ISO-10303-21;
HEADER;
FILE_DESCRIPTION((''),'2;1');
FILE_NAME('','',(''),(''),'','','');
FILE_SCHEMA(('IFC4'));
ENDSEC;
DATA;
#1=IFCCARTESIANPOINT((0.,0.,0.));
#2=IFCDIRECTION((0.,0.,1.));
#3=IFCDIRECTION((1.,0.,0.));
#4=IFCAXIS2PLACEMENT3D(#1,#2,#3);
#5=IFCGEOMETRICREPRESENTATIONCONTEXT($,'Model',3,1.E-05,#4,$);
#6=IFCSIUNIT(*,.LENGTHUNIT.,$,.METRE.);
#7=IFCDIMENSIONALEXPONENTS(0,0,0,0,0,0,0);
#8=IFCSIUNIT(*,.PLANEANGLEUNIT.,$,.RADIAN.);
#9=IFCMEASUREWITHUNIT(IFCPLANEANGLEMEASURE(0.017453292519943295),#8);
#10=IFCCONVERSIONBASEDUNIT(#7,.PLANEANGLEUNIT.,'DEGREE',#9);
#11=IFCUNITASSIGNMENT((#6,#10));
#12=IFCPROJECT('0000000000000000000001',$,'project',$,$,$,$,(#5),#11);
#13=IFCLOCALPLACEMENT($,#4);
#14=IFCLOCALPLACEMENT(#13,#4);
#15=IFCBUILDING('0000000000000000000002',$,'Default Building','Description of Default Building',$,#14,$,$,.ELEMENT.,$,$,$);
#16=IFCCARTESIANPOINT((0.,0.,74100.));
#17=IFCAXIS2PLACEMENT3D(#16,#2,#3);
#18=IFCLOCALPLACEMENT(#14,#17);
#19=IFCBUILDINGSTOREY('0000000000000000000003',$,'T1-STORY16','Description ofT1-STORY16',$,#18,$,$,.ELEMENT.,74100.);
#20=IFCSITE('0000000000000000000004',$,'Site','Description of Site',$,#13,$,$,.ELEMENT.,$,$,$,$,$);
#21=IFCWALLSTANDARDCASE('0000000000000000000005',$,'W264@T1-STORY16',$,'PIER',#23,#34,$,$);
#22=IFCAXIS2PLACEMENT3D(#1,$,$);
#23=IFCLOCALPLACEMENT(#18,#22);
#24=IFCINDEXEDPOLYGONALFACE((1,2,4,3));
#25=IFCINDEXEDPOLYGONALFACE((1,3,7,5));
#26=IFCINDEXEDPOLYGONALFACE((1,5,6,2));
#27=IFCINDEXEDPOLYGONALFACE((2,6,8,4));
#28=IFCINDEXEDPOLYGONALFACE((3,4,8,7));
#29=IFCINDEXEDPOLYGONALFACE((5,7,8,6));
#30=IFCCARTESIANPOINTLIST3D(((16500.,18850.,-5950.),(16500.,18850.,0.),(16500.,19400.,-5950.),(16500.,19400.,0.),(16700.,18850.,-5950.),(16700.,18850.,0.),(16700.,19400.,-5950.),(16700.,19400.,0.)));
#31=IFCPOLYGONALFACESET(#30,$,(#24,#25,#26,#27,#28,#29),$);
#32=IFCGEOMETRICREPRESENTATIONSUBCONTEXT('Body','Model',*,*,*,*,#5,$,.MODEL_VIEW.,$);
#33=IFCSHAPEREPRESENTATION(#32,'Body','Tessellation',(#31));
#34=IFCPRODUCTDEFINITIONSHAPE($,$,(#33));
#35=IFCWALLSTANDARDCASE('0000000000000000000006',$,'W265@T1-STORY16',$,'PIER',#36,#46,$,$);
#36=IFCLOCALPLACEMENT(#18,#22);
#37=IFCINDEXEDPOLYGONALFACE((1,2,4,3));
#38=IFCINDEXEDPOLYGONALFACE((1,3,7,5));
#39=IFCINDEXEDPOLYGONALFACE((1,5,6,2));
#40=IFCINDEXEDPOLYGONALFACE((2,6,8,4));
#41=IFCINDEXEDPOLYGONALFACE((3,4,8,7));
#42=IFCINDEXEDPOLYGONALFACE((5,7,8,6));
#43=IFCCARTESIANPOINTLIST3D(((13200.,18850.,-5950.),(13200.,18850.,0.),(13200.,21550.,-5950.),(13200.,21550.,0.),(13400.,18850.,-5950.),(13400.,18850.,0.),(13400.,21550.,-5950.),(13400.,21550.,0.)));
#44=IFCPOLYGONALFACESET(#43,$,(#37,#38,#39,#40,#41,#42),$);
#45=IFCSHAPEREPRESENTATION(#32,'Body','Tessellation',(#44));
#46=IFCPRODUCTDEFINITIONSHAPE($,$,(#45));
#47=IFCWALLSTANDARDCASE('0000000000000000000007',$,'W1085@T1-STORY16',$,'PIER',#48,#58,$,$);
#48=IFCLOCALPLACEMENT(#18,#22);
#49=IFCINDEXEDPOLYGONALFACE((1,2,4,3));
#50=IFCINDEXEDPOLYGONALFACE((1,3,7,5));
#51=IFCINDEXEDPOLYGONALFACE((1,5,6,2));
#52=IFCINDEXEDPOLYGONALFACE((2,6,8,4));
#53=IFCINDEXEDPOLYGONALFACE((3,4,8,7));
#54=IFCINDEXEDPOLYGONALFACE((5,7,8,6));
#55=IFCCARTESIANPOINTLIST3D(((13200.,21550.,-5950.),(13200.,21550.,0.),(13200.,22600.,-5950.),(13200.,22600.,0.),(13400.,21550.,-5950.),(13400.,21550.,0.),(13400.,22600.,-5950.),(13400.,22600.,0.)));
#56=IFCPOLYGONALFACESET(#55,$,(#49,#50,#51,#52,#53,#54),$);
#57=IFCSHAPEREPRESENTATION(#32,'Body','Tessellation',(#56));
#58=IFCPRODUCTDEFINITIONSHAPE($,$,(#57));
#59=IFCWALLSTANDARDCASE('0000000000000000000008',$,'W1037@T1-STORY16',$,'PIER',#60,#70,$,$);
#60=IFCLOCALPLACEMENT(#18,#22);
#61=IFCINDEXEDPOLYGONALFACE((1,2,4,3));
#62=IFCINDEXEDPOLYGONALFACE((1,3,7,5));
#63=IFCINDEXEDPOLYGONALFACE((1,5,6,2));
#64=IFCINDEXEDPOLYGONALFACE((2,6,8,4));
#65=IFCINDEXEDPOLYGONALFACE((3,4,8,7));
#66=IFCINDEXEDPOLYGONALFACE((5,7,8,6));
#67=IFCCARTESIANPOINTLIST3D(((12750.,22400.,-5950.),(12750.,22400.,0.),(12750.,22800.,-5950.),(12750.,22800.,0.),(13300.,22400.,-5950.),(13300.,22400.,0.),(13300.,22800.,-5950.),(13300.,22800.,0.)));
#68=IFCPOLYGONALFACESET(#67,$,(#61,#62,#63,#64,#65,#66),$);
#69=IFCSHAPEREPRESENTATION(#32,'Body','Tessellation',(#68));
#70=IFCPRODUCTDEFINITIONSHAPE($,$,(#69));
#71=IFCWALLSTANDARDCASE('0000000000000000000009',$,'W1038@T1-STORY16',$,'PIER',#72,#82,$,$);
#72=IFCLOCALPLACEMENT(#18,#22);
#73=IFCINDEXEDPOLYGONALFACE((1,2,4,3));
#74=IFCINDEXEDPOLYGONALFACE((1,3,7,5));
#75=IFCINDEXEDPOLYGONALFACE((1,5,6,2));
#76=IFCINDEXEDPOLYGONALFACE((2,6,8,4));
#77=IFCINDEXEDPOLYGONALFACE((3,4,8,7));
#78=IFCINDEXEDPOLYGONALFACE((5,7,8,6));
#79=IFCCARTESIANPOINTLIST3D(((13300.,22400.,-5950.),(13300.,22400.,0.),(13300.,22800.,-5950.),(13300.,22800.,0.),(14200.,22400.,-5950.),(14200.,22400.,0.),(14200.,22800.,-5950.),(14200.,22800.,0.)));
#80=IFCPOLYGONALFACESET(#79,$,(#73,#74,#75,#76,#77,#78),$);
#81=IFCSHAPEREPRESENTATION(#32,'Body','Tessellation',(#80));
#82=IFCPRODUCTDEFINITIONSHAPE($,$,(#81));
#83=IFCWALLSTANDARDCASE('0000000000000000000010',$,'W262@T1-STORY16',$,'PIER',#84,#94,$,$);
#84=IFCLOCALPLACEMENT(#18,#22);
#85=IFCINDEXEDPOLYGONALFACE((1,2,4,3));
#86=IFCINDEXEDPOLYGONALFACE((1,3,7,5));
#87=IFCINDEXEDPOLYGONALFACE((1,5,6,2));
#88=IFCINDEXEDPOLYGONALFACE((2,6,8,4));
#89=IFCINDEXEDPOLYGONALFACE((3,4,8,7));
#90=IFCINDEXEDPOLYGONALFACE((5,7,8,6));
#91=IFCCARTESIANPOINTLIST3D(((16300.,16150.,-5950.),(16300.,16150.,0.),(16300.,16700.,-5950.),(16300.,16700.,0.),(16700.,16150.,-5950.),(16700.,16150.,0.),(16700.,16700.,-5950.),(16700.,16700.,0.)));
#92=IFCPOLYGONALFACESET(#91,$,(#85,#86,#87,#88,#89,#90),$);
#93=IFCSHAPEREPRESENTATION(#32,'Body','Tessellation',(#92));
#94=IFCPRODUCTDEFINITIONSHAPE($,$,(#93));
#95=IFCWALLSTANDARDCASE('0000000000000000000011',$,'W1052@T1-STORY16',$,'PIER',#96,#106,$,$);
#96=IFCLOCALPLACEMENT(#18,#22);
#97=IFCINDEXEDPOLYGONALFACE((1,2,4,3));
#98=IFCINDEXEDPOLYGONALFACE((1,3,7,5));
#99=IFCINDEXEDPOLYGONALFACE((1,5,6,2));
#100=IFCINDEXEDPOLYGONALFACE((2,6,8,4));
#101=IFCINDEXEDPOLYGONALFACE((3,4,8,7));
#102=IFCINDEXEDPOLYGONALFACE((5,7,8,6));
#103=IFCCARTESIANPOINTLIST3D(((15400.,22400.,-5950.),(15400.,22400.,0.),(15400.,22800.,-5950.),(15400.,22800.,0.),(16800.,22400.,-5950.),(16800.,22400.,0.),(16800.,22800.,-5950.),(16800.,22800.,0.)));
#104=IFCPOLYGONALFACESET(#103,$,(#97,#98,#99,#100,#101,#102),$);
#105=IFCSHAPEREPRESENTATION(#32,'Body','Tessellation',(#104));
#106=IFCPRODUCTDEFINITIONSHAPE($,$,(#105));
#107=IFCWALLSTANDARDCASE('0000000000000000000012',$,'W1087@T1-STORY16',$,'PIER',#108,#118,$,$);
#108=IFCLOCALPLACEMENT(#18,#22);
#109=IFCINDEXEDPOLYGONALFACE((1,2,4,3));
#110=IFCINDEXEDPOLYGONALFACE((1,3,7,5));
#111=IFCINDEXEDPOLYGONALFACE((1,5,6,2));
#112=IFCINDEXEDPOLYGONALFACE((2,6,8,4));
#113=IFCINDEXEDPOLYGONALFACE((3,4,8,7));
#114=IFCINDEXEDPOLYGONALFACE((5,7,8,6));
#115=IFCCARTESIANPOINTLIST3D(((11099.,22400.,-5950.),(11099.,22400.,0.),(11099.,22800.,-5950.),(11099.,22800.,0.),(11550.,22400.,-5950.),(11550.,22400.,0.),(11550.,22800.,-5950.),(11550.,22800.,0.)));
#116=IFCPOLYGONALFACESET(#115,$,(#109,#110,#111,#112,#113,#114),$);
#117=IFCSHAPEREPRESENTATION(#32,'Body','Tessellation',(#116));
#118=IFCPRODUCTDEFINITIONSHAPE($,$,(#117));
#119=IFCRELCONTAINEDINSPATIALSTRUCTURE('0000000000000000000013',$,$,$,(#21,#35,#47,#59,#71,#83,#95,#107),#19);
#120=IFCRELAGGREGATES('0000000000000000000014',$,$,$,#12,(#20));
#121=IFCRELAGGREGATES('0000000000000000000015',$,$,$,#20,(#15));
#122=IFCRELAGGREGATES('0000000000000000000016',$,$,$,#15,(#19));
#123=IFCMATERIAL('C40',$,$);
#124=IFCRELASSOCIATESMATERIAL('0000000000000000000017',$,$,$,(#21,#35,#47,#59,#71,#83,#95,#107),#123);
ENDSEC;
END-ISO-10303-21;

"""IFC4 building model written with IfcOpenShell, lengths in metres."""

from ifc_helpers import new_model, entity, si_unit, converted_unit, frame, origin_with_axes, place, context, subcontext, project, spatial, indexed_curve, outline, extrude, material, element, save


model = new_model("IFC4")

# Units and contexts
model_context = context("Model", 3, precision=1e-05, world=origin_with_axes())
body_context = subcontext(model_context, "Body", "Model", "MODEL_VIEW")
ifc_project = project(units=[si_unit("LENGTHUNIT", "METRE"), converted_unit("PLANEANGLEUNIT", "DEGREE", entity("IfcPlaneAngleMeasure", 0.017453292519943295), si_unit("PLANEANGLEUNIT", "RADIAN"), dimensions=[0, 0, 0, 0, 0, 0, 0])], contexts=[model_context])

# Site, building, storey
site_placement = place(None, origin_with_axes())
site = spatial("IfcSite", under=ifc_project, at=site_placement, Name="Site", Description="Description of Site", CompositionType="ELEMENT")
building_placement = place(site_placement, origin_with_axes())
building = spatial("IfcBuilding", under=site, at=building_placement, Name="Default Building", Description="Description of Default Building", CompositionType="ELEMENT")
storey_placement = place(building_placement, frame((0.0, 0.0, 74100.0), z_axis=(0.0, 0.0, 1.0), x_axis=(1.0, 0.0, 0.0)))
storey = spatial("IfcBuildingStorey", under=building, at=storey_placement, Name="T1-STORY16", Description="Description ofT1-STORY16", CompositionType="ELEMENT", Elevation=74100.0)

# Walls
ifc_material_1 = material(Name="C40")
for number, where, z_axis, x_axis, name in (
    (1, (16600.0, 18850.0, -5950.0), (0.0, 0.0, 1.0), (0.0, 1.0, 0.0), "W264@T1-STORY16"),
):
    element("IfcWallStandardCase", number, at=place(storey_placement, frame(where, z_axis=z_axis, x_axis=x_axis)), inside=storey, material=ifc_material_1, Name=name, ObjectType="PIER", context=body_context, shape_type="SweptSolid", body=[
        extrude(outline(indexed_curve([(0.0, -100.0), (0.0, 100.0), (550.0, 100.0), (550.0, -100.0), (0.0, -100.0)], self_intersect=False)), origin_with_axes(), (0.0, 0.0, 1.0), 5950.0),
    ])
wall_1_placement = place(storey_placement, frame((13300.0, 18850.0, -5950.0), z_axis=(0.0, 0.0, 1.0), x_axis=(0.0, 1.0, 0.0)))
element("IfcWallStandardCase", 2, at=wall_1_placement, inside=storey, material=ifc_material_1, Name="W265@T1-STORY16", ObjectType="PIER", context=body_context, shape_type="SweptSolid", body=[
    extrude(outline(indexed_curve([(0.0, -100.0), (0.0, 100.0), (2700.0, 100.0), (2700.0, -100.0), (0.0, -100.0)], self_intersect=False)), origin_with_axes(), (0.0, 0.0, 1.0), 5950.0),
])
wall_2_placement = place(storey_placement, frame((13300.0, 21550.0, -5950.0), z_axis=(0.0, 0.0, 1.0), x_axis=(0.0, 1.0, 0.0)))
element("IfcWallStandardCase", 3, at=wall_2_placement, inside=storey, material=ifc_material_1, Name="W1085@T1-STORY16", ObjectType="PIER", context=body_context, shape_type="SweptSolid", body=[
    extrude(outline(indexed_curve([(0.0, -100.0), (0.0, 100.0), (1050.0, 100.0), (1050.0, -100.0), (0.0, -100.0)], self_intersect=False)), origin_with_axes(), (0.0, 0.0, 1.0), 5950.0),
])
wall_3_placement = place(storey_placement, frame((12750.0, 22600.0, -5950.0), z_axis=(0.0, 0.0, 1.0), x_axis=(1.0, 0.0, 0.0)))
element("IfcWallStandardCase", 4, at=wall_3_placement, inside=storey, material=ifc_material_1, Name="W1037@T1-STORY16", ObjectType="PIER", context=body_context, shape_type="SweptSolid", body=[
    extrude(outline(indexed_curve([(0.0, -200.0), (0.0, 200.0), (550.0, 200.0), (550.0, -200.0), (0.0, -200.0)], self_intersect=False)), origin_with_axes(), (0.0, 0.0, 1.0), 5950.0),
])
wall_4_placement = place(storey_placement, frame((13300.0, 22600.0, -5950.0), z_axis=(0.0, 0.0, 1.0), x_axis=(1.0, 0.0, 0.0)))
element("IfcWallStandardCase", 5, at=wall_4_placement, inside=storey, material=ifc_material_1, Name="W1038@T1-STORY16", ObjectType="PIER", context=body_context, shape_type="SweptSolid", body=[
    extrude(outline(indexed_curve([(0.0, -200.0), (0.0, 200.0), (900.0, 200.0), (900.0, -200.0), (0.0, -200.0)], self_intersect=False)), origin_with_axes(), (0.0, 0.0, 1.0), 5950.0),
])
wall_5_placement = place(storey_placement, frame((16500.0, 16150.0, -5950.0), z_axis=(0.0, 0.0, 1.0), x_axis=(0.0, 1.0, 0.0)))
element("IfcWallStandardCase", 6, at=wall_5_placement, inside=storey, material=ifc_material_1, Name="W262@T1-STORY16", ObjectType="PIER", context=body_context, shape_type="SweptSolid", body=[
    extrude(outline(indexed_curve([(0.0, -200.0), (0.0, 200.0), (550.0, 200.0), (550.0, -200.0), (0.0, -200.0)], self_intersect=False)), origin_with_axes(), (0.0, 0.0, 1.0), 5950.0),
])
wall_6_placement = place(storey_placement, frame((15400.0, 22600.0, -5950.0), z_axis=(0.0, 0.0, 1.0), x_axis=(1.0, 0.0, 0.0)))
element("IfcWallStandardCase", 7, at=wall_6_placement, inside=storey, material=ifc_material_1, Name="W1052@T1-STORY16", ObjectType="PIER", context=body_context, shape_type="SweptSolid", body=[
    extrude(outline(indexed_curve([(0.0, -200.0), (0.0, 200.0), (1400.0, 200.0), (1400.0, -200.0), (0.0, -200.0)], self_intersect=False)), origin_with_axes(), (0.0, 0.0, 1.0), 5950.0),
])
wall_7_placement = place(storey_placement, frame((11099.0, 22600.0, -5950.0), z_axis=(0.0, 0.0, 1.0), x_axis=(1.0, 0.0, 0.0)))
element("IfcWallStandardCase", 8, at=wall_7_placement, inside=storey, material=ifc_material_1, Name="W1087@T1-STORY16", ObjectType="PIER", context=body_context, shape_type="SweptSolid", body=[
    extrude(outline(indexed_curve([(0.0, -200.0), (0.0, 200.0), (451.0, 200.0), (451.0, -200.0), (0.0, -200.0)], self_intersect=False)), origin_with_axes(), (0.0, 0.0, 1.0), 5950.0),
])

save(model, "model.ifc")
